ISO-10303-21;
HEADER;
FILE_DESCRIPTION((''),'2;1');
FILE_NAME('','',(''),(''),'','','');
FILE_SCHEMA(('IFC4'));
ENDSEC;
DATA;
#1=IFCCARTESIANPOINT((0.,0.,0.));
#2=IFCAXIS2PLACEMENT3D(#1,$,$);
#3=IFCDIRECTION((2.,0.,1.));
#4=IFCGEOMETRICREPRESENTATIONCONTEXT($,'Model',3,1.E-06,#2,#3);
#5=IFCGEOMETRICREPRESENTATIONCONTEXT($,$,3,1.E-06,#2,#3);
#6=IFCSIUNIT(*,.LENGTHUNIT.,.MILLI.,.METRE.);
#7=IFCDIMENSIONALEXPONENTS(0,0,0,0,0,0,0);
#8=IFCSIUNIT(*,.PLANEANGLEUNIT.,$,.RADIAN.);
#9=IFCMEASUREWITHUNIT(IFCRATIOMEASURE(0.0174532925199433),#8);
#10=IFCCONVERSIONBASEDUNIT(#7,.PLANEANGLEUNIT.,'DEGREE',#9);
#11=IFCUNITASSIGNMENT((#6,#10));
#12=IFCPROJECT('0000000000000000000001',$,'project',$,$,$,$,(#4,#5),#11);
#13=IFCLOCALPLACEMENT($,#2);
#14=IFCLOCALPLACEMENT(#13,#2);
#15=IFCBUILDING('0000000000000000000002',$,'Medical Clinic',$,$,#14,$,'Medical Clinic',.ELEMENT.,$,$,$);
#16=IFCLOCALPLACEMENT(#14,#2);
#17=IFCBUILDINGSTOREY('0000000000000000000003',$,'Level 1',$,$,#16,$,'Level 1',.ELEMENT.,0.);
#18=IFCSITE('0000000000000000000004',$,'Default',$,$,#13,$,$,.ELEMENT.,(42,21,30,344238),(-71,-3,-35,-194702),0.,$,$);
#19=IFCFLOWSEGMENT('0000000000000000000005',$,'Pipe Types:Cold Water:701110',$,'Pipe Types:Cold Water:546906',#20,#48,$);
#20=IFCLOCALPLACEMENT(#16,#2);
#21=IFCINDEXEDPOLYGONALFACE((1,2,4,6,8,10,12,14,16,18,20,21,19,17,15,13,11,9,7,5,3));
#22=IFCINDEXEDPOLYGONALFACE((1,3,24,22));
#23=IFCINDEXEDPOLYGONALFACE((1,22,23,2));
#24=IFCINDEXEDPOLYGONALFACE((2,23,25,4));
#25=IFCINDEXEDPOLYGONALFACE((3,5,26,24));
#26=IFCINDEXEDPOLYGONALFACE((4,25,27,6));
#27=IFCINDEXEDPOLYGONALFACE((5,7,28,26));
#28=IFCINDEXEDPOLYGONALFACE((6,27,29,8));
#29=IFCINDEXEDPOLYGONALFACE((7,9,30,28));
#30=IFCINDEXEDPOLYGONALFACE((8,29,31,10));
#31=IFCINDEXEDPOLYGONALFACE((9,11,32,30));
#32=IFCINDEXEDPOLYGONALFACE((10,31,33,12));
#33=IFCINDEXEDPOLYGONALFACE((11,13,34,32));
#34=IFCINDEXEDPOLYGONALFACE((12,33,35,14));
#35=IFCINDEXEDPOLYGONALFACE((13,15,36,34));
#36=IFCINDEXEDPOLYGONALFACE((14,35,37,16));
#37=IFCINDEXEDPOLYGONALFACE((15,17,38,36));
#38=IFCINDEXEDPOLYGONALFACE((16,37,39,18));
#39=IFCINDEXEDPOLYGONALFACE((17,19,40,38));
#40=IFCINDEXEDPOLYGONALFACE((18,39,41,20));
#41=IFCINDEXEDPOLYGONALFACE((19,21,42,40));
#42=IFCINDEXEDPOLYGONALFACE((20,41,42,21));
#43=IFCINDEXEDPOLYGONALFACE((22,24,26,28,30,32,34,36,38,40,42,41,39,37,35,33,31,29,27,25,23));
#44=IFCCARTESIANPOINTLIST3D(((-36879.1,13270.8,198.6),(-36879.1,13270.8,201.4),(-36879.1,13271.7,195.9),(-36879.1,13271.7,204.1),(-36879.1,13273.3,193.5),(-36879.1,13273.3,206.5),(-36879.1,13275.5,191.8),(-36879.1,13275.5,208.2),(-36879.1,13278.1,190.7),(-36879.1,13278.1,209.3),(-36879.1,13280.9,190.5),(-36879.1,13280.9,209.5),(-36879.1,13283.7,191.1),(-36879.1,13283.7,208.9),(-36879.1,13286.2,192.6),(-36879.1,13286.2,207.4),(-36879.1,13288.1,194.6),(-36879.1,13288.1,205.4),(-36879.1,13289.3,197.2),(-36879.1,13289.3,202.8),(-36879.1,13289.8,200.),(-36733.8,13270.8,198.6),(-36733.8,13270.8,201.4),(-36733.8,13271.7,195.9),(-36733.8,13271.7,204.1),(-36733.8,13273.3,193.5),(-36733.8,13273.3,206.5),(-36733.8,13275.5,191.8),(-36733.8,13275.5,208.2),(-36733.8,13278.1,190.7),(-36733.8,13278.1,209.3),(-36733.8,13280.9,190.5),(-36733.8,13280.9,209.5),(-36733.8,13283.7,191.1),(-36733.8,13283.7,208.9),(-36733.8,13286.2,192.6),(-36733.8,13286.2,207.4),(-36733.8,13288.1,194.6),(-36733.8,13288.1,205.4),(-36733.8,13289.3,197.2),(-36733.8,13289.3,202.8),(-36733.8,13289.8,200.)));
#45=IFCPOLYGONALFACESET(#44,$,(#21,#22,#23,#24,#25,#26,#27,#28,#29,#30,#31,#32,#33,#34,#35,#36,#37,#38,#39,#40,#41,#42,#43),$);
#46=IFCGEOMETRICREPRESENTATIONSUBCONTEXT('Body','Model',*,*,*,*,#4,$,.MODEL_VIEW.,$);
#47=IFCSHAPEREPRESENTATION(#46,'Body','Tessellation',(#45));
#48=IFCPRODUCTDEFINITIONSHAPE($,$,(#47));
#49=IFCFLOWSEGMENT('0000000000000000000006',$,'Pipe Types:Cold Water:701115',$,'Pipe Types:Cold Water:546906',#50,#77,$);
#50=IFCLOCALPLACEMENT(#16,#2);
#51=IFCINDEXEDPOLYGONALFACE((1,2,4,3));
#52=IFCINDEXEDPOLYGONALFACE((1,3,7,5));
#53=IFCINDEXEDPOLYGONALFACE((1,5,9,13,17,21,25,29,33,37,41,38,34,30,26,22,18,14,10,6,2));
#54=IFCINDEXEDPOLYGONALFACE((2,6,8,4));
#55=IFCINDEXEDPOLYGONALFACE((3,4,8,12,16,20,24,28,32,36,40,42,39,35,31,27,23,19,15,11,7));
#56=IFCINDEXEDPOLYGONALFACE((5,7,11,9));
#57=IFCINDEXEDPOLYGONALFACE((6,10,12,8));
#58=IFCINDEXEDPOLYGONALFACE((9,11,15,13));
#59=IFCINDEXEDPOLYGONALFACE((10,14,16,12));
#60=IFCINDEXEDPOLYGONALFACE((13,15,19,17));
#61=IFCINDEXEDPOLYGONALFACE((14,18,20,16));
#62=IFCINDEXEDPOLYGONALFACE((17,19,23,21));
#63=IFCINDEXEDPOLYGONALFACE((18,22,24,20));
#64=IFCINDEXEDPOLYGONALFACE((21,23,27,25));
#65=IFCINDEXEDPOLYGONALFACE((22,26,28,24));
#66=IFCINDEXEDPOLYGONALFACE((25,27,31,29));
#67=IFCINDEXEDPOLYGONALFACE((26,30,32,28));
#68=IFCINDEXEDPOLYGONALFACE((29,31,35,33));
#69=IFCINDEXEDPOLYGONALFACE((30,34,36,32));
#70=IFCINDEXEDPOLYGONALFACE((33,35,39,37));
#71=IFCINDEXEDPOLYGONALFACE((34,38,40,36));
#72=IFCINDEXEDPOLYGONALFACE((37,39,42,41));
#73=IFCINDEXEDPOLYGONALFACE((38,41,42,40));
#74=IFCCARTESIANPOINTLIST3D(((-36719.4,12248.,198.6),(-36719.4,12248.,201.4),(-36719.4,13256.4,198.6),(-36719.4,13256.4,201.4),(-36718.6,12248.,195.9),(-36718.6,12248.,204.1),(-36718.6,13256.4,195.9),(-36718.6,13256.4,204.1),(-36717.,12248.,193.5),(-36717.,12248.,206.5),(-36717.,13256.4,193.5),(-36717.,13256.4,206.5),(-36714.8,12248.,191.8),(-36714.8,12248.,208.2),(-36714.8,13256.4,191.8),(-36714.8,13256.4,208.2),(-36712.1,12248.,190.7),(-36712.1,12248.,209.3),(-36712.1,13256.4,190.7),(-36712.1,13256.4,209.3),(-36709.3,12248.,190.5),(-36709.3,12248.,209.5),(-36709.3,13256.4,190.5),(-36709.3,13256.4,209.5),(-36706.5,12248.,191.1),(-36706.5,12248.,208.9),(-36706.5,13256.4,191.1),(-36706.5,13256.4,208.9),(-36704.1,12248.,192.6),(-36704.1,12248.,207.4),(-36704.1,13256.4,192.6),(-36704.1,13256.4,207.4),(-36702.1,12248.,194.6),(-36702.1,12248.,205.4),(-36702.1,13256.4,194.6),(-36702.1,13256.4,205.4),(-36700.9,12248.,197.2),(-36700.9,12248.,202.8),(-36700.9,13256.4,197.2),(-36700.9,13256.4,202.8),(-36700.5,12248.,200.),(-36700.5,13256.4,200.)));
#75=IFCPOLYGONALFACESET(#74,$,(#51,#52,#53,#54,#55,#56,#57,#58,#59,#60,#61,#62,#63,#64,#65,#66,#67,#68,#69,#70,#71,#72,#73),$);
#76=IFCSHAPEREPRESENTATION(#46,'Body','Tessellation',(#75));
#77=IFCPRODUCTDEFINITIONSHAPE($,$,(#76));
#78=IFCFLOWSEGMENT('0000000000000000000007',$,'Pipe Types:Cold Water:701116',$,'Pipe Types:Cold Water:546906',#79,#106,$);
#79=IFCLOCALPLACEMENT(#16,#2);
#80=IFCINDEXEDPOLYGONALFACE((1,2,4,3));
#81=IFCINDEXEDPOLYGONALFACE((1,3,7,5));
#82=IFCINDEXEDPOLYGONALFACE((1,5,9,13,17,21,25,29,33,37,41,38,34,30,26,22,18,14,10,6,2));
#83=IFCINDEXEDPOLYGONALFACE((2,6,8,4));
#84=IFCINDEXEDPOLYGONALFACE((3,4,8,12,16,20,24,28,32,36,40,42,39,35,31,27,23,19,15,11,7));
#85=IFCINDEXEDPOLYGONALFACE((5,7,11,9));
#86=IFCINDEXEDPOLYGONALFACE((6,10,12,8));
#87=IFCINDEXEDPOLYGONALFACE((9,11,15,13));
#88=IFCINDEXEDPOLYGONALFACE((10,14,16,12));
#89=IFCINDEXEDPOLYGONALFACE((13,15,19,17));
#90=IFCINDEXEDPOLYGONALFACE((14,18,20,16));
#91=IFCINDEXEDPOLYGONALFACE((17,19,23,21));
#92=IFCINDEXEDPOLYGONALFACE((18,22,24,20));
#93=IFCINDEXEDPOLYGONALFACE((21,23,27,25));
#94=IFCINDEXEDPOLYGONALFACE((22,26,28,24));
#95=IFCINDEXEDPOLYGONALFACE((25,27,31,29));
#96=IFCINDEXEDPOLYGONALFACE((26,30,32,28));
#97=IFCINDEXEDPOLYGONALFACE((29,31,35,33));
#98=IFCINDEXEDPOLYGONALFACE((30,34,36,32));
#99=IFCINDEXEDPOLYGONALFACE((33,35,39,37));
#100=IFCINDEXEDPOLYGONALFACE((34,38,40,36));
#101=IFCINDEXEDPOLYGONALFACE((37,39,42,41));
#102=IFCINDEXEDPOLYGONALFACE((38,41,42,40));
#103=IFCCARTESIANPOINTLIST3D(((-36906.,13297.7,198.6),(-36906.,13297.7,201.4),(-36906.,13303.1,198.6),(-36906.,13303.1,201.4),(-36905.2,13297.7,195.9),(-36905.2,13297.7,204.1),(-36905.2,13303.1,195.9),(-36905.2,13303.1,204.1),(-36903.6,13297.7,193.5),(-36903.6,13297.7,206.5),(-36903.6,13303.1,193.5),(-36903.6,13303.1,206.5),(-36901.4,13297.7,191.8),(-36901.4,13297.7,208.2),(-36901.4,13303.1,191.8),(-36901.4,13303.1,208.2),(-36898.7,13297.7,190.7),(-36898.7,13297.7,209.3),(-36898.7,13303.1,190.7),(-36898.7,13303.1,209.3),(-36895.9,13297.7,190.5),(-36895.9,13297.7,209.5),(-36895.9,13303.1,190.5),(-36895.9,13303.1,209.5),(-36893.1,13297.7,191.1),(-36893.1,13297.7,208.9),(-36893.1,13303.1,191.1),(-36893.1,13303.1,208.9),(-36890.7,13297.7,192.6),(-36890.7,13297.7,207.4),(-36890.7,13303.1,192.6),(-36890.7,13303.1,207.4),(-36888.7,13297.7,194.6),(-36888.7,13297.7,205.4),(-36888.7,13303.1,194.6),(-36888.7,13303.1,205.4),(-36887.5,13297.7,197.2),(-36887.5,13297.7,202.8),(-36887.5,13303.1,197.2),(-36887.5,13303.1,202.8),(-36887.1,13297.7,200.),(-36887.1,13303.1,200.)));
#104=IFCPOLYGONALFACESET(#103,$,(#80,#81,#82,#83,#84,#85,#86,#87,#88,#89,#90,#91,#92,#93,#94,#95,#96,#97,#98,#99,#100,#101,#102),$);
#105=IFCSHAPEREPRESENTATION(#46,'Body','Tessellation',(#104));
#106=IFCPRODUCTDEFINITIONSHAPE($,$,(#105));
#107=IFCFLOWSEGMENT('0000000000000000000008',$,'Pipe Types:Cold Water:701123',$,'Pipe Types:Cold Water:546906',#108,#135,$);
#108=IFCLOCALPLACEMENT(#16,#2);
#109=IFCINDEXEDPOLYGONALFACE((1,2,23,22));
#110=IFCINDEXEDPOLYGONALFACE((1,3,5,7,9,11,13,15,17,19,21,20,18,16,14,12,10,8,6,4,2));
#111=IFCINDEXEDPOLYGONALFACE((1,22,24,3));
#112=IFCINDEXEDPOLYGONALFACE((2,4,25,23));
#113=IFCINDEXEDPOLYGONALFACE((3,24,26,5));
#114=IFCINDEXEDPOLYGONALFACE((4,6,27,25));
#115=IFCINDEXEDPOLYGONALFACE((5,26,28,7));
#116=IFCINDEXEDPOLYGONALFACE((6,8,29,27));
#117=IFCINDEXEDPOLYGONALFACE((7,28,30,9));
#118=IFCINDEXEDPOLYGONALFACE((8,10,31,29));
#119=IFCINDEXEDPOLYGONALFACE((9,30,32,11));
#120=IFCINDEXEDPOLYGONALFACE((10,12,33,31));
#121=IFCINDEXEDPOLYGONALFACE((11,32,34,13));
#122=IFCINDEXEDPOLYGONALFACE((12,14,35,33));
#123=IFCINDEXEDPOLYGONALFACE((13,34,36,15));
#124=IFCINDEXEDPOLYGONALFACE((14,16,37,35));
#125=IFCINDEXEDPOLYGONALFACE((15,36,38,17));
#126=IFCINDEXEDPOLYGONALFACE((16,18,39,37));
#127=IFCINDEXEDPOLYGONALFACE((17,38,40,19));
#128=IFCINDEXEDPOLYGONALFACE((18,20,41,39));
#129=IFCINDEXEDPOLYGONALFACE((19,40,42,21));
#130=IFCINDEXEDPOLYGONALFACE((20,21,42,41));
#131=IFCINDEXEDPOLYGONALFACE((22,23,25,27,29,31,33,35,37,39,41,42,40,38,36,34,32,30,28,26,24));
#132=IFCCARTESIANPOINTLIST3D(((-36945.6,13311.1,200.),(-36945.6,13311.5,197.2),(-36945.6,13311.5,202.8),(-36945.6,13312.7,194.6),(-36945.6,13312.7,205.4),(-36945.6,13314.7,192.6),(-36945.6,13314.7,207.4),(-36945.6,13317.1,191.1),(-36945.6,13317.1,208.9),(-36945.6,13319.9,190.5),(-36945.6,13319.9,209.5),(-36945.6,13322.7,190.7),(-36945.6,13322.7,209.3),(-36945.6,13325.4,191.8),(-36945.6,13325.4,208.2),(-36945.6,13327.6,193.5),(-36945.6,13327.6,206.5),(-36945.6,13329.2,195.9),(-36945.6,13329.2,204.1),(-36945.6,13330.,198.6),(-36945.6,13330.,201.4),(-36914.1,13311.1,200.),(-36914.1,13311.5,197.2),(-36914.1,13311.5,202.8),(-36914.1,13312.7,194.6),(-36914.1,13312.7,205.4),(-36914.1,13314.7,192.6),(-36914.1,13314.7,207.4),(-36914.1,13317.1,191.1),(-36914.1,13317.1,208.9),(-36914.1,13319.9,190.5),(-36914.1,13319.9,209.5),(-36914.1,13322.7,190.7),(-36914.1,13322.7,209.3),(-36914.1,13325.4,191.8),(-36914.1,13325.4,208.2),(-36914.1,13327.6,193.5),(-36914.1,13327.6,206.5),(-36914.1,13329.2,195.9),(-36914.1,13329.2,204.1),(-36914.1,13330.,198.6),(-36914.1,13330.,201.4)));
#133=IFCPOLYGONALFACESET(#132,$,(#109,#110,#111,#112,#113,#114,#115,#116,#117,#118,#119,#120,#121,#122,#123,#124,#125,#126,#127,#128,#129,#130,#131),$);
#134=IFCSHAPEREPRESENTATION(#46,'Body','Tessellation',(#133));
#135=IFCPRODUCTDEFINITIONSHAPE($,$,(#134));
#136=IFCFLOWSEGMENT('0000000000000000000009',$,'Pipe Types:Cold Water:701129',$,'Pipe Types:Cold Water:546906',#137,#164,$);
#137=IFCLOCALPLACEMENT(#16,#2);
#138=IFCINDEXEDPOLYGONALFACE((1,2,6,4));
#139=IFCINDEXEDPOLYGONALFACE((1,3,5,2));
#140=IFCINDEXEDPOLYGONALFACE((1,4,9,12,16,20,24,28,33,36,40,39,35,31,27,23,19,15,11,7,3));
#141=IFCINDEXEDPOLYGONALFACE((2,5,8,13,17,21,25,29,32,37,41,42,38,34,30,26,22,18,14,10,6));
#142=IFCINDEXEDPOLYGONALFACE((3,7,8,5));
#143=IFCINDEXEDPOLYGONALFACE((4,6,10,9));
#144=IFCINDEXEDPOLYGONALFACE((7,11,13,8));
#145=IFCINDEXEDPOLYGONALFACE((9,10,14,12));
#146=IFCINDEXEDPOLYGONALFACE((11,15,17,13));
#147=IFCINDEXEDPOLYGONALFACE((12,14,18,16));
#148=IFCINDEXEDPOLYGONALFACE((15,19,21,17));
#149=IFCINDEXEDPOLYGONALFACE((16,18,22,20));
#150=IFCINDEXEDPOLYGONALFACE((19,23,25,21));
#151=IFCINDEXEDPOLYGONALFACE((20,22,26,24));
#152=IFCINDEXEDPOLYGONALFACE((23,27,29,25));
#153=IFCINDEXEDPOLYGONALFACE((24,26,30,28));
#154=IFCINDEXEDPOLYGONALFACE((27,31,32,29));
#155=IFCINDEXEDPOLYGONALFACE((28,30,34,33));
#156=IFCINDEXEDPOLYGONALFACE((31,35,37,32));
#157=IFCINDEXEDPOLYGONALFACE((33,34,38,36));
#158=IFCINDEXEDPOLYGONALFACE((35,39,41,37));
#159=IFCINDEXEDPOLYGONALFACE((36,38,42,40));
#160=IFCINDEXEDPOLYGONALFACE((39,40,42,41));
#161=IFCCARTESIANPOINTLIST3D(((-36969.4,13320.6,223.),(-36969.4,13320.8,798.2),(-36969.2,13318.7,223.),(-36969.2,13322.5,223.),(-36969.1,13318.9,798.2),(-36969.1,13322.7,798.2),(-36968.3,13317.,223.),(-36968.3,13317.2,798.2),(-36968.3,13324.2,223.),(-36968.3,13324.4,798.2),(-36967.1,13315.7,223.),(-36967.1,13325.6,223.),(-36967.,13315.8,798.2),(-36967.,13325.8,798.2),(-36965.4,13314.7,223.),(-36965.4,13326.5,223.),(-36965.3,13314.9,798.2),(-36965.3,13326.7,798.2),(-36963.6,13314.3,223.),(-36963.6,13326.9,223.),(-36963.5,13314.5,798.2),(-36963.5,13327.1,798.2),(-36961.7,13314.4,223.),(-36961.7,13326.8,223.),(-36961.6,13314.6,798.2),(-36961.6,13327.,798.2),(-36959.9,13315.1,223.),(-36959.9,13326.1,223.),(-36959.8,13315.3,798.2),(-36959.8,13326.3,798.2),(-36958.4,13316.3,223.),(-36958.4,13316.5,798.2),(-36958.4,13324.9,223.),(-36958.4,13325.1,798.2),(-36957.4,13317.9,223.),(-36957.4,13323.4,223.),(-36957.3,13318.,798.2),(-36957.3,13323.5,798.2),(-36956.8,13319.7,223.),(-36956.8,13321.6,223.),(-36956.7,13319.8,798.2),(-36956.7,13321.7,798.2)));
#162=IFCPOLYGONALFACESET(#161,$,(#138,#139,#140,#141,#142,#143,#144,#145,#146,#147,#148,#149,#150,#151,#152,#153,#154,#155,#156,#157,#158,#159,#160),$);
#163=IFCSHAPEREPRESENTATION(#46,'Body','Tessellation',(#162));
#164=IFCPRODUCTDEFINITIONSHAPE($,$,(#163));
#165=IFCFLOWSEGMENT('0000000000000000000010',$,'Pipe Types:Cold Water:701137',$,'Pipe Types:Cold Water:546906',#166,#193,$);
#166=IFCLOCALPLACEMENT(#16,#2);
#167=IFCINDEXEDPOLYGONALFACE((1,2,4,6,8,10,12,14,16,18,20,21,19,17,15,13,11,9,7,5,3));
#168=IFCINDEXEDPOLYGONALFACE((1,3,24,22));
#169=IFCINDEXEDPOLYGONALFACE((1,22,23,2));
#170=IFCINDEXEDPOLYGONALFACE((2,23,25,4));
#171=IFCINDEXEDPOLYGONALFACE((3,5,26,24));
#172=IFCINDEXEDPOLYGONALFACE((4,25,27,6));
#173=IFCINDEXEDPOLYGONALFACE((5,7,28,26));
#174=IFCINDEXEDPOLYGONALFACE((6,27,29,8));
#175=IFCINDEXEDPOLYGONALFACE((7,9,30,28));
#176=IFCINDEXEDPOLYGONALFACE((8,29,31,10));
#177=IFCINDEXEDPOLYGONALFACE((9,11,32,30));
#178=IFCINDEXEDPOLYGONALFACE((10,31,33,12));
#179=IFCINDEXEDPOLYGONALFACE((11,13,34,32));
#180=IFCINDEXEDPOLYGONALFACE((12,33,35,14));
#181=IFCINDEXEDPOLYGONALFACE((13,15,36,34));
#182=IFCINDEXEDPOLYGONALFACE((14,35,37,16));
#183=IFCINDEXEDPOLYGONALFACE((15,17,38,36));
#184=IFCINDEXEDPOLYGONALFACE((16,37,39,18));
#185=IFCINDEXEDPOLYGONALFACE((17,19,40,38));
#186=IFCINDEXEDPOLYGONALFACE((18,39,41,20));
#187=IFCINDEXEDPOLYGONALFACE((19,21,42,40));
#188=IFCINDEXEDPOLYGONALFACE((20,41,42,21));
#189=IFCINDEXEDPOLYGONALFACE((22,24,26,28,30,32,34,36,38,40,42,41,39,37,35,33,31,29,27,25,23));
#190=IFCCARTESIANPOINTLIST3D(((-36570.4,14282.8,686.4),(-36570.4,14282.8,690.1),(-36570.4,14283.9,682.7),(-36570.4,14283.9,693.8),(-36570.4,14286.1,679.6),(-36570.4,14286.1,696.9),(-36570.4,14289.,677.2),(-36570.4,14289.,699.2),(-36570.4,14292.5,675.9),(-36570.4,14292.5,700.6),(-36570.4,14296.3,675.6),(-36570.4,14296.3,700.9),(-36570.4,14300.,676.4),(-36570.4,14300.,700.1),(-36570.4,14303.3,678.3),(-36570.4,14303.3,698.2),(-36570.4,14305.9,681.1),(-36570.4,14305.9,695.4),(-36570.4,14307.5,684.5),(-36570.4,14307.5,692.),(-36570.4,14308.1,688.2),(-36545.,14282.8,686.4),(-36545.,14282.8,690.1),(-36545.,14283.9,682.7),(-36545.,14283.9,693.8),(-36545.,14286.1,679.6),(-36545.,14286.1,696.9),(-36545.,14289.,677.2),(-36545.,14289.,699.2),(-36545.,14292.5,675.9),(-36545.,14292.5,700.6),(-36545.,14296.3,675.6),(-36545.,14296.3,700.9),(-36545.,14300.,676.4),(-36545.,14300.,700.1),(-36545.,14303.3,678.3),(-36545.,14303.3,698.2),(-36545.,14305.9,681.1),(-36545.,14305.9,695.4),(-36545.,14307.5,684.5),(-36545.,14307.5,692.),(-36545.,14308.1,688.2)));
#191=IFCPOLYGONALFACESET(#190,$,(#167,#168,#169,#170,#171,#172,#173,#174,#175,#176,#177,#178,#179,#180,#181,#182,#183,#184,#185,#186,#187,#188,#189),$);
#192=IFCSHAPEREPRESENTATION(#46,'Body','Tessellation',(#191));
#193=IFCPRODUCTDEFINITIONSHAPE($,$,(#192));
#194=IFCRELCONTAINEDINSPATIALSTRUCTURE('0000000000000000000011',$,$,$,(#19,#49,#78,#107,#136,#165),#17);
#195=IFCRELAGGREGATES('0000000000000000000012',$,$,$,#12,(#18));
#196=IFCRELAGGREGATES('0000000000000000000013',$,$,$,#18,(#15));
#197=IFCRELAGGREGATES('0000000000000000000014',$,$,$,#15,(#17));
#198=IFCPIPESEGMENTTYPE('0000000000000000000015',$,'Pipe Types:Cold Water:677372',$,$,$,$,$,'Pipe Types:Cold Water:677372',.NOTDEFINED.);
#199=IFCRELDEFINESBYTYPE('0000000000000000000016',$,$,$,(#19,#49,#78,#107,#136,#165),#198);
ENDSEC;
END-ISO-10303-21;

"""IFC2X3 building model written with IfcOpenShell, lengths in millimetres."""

from ifc_helpers import new_model, entity, si_unit, converted_unit, direction, frame, frame_2d, origin, origin_2d_with_axis, place, context, subcontext, project, spatial, circle, extrude, type_object, element, save


model = new_model("IFC2X3")

# Units and contexts
model_context = context("Model", 3, precision=1e-06, world=origin(), true_north=direction((2.0, 0.0, 1.0)))
context_of_model = context(None, 3, precision=1e-06, world=origin(), true_north=direction((2.0, 0.0, 1.0)))
body_context = subcontext(model_context, "Body", "Model", "MODEL_VIEW")
ifc_project = project(units=[si_unit("LENGTHUNIT", "METRE", prefix="MILLI"), converted_unit("PLANEANGLEUNIT", "DEGREE", entity("IfcRatioMeasure", 0.0174532925199433), si_unit("PLANEANGLEUNIT", "RADIAN"), dimensions=[0, 0, 0, 0, 0, 0, 0])], contexts=[model_context, context_of_model])

# Site, building, storey
site_placement = place(None, origin())
site = spatial("IfcSite", under=ifc_project, at=site_placement, Name="Default", CompositionType="ELEMENT", RefLatitude=(42, 21, 30, 344238), RefLongitude=(-71, -3, -35, -194702), RefElevation=0.0)
building_placement = place(site_placement, origin())
building = spatial("IfcBuilding", under=site, at=building_placement, Name="Medical Clinic", LongName="Medical Clinic", CompositionType="ELEMENT")
storey_placement = place(building_placement, origin())
storey = spatial("IfcBuildingStorey", under=building, at=storey_placement, Name="Level 1", LongName="Level 1", CompositionType="ELEMENT", Elevation=0.0)

# Flow segments
pipe_segment_type_1 = type_object("IfcPipeSegmentType", Name="Pipe Types:Cold Water:677372", ElementType="Pipe Types:Cold Water:677372", PredefinedType="NOTDEFINED")
flow_segment_1_placement = place(storey_placement, origin())
element("IfcFlowSegment", 1, at=flow_segment_1_placement, inside=storey, type_object=pipe_segment_type_1, Name="Pipe Types:Cold Water:701110", ObjectType="Pipe Types:Cold Water:546906", context=body_context, shape_type="SweptSolid", body=[
    extrude(circle(Radius=9.5, at=frame_2d((0.0, 0.0), x_axis=(1.0, 0.0))), frame((-36879.1, 13280.2, 200.0), z_axis=(1.0, 0.0, 0.0), x_axis=(0.0, 1.0, 0.0)), (0.0, 0.0, 1.0), 145.3),
])
flow_segment_2_placement = place(storey_placement, origin())
element("IfcFlowSegment", 2, at=flow_segment_2_placement, inside=storey, type_object=pipe_segment_type_1, Name="Pipe Types:Cold Water:701115", ObjectType="Pipe Types:Cold Water:546906", context=body_context, shape_type="SweptSolid", body=[
    extrude(circle(Radius=9.5, at=origin_2d_with_axis()), frame((-36710.0, 12248.0, 200.0), z_axis=(0.0, 1.0, 0.0), x_axis=(1.0, 0.0, 0.0)), (0.0, 0.0, 1.0), 1008.4),
])
flow_segment_3_placement = place(storey_placement, origin())
element("IfcFlowSegment", 3, at=flow_segment_3_placement, inside=storey, type_object=pipe_segment_type_1, Name="Pipe Types:Cold Water:701116", ObjectType="Pipe Types:Cold Water:546906", context=body_context, shape_type="SweptSolid", body=[
    extrude(circle(Radius=9.5, at=origin_2d_with_axis()), frame((-36896.6, 13297.7, 200.0), z_axis=(0.0, 1.0, 0.0), x_axis=(1.0, 0.0, 0.0)), (0.0, 0.0, 1.0), 5.4),
])
flow_segment_4_placement = place(storey_placement, origin())
element("IfcFlowSegment", 4, at=flow_segment_4_placement, inside=storey, type_object=pipe_segment_type_1, Name="Pipe Types:Cold Water:701123", ObjectType="Pipe Types:Cold Water:546906", context=body_context, shape_type="SweptSolid", body=[
    extrude(circle(Radius=9.5, at=origin_2d_with_axis()), frame((-36945.6, 13320.6, 200.0), z_axis=(1.0, 0.0, 0.0), x_axis=(0.0, -1.0, 0.0)), (0.0, 0.0, 1.0), 31.6),
])
flow_segment_5_placement = place(storey_placement, origin())
element("IfcFlowSegment", 5, at=flow_segment_5_placement, inside=storey, type_object=pipe_segment_type_1, Name="Pipe Types:Cold Water:701129", ObjectType="Pipe Types:Cold Water:546906", context=body_context, shape_type="SweptSolid", body=[
    extrude(circle(Radius=6.3, at=frame_2d((0.0, 0.0), x_axis=(1.0, 0.0))), frame((-36963.1, 13320.6, 223.0), z_axis=(0.000144, 0.000301, 1.0), x_axis=(-1.0, 0.0, 0.000144)), (0.0, 0.0, 1.0), 575.2),
])
flow_segment_6_placement = place(storey_placement, origin())
element("IfcFlowSegment", 6, at=flow_segment_6_placement, inside=storey, type_object=pipe_segment_type_1, Name="Pipe Types:Cold Water:701137", ObjectType="Pipe Types:Cold Water:546906", context=body_context, shape_type="SweptSolid", body=[
    extrude(circle(Radius=12.7, at=frame_2d((0.0, 0.0), x_axis=(1.0, 0.0))), frame((-36570.4, 14295.4, 688.2), z_axis=(1.0, 0.0, 0.0), x_axis=(0.0, 1.0, 0.0)), (0.0, 0.0, 1.0), 25.4),
])

save(model, "model.ifc")
